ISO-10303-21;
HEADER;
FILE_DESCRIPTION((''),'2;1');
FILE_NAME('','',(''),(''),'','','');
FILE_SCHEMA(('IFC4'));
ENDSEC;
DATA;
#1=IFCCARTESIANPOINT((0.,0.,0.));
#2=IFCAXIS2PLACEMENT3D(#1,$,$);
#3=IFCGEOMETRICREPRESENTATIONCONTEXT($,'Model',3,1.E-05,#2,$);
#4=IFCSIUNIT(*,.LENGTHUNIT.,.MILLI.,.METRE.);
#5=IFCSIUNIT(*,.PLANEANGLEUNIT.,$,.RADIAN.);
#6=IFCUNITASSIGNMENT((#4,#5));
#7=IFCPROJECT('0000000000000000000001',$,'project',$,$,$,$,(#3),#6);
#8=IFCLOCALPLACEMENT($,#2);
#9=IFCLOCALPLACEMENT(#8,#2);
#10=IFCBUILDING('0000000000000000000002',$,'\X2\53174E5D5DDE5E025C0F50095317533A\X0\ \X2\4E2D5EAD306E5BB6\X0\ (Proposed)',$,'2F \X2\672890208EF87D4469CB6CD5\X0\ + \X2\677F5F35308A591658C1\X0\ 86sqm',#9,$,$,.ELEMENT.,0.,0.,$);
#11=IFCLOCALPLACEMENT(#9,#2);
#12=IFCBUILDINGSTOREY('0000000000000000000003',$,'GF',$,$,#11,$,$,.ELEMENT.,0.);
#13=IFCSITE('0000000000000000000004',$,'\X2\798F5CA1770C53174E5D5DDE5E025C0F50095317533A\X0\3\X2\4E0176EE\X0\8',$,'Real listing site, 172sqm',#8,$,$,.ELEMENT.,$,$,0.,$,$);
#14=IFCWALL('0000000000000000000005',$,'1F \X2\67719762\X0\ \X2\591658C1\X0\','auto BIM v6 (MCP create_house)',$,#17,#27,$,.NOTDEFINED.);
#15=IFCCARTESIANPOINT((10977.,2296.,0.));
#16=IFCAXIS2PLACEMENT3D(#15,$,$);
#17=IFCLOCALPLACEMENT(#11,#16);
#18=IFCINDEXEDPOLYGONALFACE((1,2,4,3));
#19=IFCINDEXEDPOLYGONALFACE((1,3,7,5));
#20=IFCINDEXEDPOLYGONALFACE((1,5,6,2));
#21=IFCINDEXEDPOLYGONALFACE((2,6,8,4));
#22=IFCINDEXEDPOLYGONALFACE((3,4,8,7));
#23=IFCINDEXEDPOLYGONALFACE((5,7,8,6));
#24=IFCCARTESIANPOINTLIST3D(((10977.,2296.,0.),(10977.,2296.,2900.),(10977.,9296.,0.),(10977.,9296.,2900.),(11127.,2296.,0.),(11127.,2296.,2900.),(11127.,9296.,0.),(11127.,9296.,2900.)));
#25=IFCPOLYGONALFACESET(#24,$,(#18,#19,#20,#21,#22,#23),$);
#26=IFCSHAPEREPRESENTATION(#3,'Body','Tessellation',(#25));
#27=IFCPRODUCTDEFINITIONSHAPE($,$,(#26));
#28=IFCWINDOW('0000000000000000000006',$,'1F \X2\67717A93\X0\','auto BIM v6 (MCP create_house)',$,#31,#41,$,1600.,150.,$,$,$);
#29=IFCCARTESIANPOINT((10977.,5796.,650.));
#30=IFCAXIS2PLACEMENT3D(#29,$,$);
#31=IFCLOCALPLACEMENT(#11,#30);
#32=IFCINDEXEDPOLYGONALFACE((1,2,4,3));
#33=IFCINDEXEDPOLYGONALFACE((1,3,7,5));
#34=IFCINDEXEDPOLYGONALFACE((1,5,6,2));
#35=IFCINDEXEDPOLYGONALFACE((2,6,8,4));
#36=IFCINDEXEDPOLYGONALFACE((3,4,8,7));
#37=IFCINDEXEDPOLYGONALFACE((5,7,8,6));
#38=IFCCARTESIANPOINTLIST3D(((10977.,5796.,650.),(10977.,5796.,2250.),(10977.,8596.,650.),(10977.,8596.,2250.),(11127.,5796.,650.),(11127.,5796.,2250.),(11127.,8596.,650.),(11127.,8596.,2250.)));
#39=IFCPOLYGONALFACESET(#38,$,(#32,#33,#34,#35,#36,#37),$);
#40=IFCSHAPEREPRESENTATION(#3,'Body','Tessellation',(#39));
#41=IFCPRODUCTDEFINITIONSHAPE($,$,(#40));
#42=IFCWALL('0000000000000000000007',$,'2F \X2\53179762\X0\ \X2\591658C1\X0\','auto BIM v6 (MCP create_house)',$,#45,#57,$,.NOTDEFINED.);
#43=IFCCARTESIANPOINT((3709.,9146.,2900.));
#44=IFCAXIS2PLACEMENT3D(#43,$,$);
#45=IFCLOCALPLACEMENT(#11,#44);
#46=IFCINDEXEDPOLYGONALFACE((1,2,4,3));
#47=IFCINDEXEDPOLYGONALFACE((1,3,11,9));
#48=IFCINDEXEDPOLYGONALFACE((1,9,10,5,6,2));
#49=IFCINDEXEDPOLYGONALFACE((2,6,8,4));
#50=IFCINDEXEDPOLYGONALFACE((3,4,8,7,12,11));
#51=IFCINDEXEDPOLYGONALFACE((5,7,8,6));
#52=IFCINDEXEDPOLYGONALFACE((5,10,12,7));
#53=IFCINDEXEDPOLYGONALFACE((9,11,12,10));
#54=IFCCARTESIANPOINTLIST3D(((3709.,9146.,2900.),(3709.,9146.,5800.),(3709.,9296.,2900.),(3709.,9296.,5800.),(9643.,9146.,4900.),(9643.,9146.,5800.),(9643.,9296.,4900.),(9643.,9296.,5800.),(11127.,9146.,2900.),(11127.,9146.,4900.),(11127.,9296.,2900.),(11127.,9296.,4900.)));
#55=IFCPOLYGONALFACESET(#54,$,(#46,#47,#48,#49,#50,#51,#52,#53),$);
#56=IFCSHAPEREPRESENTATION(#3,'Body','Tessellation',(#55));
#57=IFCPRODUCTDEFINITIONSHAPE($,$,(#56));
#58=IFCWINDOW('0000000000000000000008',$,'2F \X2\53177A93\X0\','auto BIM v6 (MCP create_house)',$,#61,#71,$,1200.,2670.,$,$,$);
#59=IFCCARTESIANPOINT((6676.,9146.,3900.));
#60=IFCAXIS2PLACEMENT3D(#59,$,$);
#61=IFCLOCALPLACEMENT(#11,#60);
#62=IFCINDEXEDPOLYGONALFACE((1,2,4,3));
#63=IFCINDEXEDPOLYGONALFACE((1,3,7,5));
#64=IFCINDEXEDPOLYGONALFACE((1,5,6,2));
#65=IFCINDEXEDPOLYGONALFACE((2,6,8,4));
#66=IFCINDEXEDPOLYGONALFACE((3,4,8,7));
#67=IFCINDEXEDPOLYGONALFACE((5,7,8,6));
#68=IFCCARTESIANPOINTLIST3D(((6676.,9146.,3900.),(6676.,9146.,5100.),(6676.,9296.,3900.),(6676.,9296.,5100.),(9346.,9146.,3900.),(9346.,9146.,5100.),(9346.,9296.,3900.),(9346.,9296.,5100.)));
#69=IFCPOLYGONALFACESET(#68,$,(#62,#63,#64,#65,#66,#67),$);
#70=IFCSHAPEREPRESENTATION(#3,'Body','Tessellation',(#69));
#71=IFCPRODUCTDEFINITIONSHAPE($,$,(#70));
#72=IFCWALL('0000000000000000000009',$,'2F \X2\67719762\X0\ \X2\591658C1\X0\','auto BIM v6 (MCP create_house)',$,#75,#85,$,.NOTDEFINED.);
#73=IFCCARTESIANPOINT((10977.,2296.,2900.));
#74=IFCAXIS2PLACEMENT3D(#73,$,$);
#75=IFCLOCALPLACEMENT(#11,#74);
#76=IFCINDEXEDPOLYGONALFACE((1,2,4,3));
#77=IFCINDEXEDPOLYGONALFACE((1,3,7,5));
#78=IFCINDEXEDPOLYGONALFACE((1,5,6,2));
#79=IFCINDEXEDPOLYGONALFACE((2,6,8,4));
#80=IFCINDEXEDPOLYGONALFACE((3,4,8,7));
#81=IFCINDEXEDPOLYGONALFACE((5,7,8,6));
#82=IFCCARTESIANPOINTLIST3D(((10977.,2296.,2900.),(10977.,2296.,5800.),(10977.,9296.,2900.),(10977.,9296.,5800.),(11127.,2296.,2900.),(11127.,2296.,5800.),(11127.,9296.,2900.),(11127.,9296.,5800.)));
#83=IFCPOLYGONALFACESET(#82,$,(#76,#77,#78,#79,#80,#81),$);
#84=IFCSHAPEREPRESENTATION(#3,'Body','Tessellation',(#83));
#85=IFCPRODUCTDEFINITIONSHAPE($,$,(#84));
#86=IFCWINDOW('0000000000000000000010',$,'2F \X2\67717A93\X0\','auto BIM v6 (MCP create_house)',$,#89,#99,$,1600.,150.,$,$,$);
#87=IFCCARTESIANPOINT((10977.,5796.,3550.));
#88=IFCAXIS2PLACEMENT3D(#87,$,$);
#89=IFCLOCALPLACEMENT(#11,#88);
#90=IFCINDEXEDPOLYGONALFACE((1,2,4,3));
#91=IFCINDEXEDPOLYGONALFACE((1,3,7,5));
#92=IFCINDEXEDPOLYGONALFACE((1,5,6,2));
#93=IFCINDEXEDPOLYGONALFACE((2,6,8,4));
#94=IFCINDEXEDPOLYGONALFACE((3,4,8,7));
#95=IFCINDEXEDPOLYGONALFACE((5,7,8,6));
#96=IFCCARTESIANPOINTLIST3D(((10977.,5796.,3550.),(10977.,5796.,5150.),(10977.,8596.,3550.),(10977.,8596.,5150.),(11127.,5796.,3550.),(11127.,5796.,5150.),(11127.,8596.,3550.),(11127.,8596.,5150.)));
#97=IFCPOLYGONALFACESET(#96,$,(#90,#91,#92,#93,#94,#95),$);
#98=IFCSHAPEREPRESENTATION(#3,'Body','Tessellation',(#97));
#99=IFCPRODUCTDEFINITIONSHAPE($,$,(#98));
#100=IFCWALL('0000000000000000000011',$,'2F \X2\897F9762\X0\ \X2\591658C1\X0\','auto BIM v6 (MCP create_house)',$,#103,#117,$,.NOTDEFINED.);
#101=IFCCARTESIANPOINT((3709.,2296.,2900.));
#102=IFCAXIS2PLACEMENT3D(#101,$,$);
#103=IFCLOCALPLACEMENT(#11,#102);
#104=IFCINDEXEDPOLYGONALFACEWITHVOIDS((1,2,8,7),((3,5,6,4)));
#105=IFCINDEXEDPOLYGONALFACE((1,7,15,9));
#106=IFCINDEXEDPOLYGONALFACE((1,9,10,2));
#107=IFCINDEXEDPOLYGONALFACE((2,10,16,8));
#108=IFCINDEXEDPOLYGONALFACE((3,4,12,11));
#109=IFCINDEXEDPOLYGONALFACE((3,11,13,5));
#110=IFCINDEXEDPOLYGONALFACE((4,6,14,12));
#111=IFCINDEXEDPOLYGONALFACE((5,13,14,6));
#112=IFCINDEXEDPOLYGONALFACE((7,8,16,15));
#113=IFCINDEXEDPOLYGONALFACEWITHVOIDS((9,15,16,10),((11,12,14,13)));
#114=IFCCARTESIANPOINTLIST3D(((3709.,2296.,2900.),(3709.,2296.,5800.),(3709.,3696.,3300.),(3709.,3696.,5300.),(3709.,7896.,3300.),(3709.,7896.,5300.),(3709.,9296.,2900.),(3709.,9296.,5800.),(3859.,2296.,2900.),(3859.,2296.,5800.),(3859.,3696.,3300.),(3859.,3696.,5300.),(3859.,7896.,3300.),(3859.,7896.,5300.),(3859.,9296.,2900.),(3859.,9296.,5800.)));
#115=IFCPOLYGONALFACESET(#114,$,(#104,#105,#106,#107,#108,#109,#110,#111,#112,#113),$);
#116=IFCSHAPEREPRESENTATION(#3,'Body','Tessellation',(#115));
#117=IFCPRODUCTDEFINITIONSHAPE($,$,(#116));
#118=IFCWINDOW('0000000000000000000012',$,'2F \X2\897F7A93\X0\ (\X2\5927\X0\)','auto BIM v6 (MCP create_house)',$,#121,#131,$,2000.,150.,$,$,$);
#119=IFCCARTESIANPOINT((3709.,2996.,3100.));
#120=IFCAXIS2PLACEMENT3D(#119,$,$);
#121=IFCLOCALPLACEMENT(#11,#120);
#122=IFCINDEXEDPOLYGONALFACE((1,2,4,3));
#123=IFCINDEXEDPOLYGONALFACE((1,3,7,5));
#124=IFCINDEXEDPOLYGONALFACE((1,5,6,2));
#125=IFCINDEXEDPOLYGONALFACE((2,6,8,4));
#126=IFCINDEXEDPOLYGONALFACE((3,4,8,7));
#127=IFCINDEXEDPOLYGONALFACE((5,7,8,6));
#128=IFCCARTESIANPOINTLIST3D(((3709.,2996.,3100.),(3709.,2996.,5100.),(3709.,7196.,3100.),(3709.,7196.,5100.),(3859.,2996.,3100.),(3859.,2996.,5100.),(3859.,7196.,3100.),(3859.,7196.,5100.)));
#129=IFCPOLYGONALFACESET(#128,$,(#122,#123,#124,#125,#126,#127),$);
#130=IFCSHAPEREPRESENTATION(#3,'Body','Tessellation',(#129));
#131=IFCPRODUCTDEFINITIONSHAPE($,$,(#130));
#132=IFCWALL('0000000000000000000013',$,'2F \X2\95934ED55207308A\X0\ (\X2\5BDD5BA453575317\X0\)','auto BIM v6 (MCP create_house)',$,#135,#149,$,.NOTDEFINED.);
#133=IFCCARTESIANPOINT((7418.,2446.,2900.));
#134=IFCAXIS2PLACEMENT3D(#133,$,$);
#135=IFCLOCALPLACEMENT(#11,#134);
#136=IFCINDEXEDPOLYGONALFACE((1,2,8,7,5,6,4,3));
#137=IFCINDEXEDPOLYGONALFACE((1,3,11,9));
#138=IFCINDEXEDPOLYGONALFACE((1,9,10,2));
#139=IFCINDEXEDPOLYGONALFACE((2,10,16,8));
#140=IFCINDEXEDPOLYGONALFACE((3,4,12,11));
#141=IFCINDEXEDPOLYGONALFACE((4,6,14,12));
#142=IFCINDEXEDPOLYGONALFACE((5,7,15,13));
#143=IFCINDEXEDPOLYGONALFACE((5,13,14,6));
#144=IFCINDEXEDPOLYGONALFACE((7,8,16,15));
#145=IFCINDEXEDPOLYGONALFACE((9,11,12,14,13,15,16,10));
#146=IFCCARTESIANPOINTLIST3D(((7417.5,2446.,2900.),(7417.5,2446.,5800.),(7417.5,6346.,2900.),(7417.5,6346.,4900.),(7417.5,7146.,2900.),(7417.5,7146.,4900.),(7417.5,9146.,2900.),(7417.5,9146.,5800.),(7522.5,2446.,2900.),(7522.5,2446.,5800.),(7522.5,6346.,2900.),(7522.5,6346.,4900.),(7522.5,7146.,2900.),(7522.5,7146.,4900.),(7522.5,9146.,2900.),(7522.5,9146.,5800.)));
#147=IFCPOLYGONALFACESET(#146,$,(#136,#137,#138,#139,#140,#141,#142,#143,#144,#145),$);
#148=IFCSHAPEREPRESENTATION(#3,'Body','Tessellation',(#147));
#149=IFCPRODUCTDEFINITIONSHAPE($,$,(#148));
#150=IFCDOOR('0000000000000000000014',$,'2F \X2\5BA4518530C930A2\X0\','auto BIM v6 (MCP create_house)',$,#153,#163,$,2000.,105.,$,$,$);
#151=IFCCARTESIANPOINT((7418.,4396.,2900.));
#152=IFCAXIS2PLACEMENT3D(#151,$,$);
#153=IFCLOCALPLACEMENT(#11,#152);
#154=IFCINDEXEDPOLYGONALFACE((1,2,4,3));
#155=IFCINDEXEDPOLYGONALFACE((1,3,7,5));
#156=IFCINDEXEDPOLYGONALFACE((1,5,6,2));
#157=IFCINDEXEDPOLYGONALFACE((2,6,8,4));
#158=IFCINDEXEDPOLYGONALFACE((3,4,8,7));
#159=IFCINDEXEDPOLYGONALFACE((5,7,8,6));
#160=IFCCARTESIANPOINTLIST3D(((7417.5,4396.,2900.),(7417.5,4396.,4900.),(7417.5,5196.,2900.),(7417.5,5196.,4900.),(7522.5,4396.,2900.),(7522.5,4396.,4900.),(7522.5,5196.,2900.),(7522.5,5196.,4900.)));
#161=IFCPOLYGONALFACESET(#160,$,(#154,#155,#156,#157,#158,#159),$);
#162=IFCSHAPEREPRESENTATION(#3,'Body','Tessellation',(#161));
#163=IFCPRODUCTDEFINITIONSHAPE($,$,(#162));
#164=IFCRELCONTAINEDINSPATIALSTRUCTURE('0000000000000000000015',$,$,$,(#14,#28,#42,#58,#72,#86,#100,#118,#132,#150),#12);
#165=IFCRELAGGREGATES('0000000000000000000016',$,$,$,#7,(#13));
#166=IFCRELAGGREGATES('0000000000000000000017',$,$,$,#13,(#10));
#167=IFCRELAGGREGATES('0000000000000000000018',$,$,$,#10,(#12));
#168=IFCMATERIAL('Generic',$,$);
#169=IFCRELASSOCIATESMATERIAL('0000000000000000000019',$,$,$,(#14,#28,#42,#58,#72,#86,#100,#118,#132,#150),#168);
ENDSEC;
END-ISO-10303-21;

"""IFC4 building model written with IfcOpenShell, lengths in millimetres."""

from ifc_helpers import new_model, si_unit, frame, frame_2d, origin, place, context, project, spatial, rectangle, extrude, material, element, fill, save


model = new_model("IFC4")

# Units and contexts
model_context = context("Model", 3, precision=1e-05, world=origin())
ifc_project = project(units=[si_unit("LENGTHUNIT", "METRE", prefix="MILLI"), si_unit("PLANEANGLEUNIT", "RADIAN")], contexts=[model_context])

# Site, building, storey
site_placement = place(None, origin())
site = spatial("IfcSite", under=ifc_project, at=site_placement, Name="福岡県北九州市小倉北区3丁目8", ObjectType="Real listing site, 172sqm", CompositionType="ELEMENT", RefElevation=0.0)
building_placement = place(site_placement, origin())
building = spatial("IfcBuilding", under=site, at=building_placement, Name="北九州市小倉北区 中庭の家 (Proposed)", ObjectType="2F 木造軸組構法 + 板張り外壁 86sqm", CompositionType="ELEMENT", ElevationOfRefHeight=0.0, ElevationOfTerrain=0.0)
storey_placement = place(building_placement, origin())
storey = spatial("IfcBuildingStorey", under=building, at=storey_placement, Name="GF", CompositionType="ELEMENT", Elevation=0.0)

# Shared definitions
ifc_material = material(Name="Generic")

# Wall, opening, window
wall_1_placement = place(storey_placement, frame((10977.0, 2296.0, 0.0)))
wall_1 = element("IfcWall", 1, at=wall_1_placement, inside=storey, material=ifc_material, Name="1F 東面 外壁", Description="auto BIM v6 (MCP create_house)", PredefinedType="NOTDEFINED", context=model_context, shape_type="SweptSolid", body=[
    extrude(rectangle(XDim=150.0, YDim=7000.0, at=frame_2d((75.0, 3500.0))), frame((10977.0, 2296.0, 0.0)), (0.0, 0.0, 1.0), 2900.0),
])
opening_1_placement = place(storey_placement, frame((10977.0, 5796.0, 650.0)))
opening_1 = element("IfcOpeningElement", 2, at=opening_1_placement, cuts=wall_1, PredefinedType="NOTDEFINED", context=model_context, shape_type="SweptSolid", body=[
    extrude(rectangle(XDim=150.0, YDim=2800.0, at=frame_2d((75.0, 1400.0))), frame((10977.0, 5796.0, 650.0)), (0.0, 0.0, 1.0), 1600.0),
])
window_1_placement = place(storey_placement, frame((10977.0, 5796.0, 650.0)))
window_1 = element("IfcWindow", 3, at=window_1_placement, inside=storey, material=ifc_material, Name="1F 東窓", Description="auto BIM v6 (MCP create_house)", OverallHeight=1600.0, OverallWidth=150.0, context=model_context, shape_type="SweptSolid", body=[
    extrude(rectangle(XDim=150.0, YDim=2800.0, at=frame_2d((75.0, 1400.0))), frame((10977.0, 5796.0, 650.0)), (0.0, 0.0, 1.0), 1600.0),
])
fill(opening_1, window_1)

# Walls, openings, windows
wall_2_placement = place(storey_placement, frame((3709.0, 9146.0, 2900.0)))
wall_2 = element("IfcWall", 4, at=wall_2_placement, inside=storey, material=ifc_material, Name="2F 北面 外壁", Description="auto BIM v6 (MCP create_house)", PredefinedType="NOTDEFINED", context=model_context, shape_type="SweptSolid", body=[
    extrude(rectangle(XDim=7418.0, YDim=150.0, at=frame_2d((3709.0, 75.0))), frame((3709.0, 9146.0, 2900.0)), (0.0, 0.0, 1.0), 2900.0),
])
opening_2_placement = place(storey_placement, frame((6676.0, 9146.0, 3900.0)))
opening_2 = element("IfcOpeningElement", 5, at=opening_2_placement, cuts=wall_2, PredefinedType="NOTDEFINED", context=model_context, shape_type="SweptSolid", body=[
    extrude(rectangle(XDim=2670.0, YDim=150.0, at=frame_2d((1335.0, 75.0))), frame((6676.0, 9146.0, 3900.0)), (0.0, 0.0, 1.0), 1200.0),
])
window_2_placement = place(storey_placement, frame((6676.0, 9146.0, 3900.0)))
window_2 = element("IfcWindow", 6, at=window_2_placement, inside=storey, material=ifc_material, Name="2F 北窓", Description="auto BIM v6 (MCP create_house)", OverallHeight=1200.0, OverallWidth=2670.0, context=model_context, shape_type="SweptSolid", body=[
    extrude(rectangle(XDim=2670.0, YDim=150.0, at=frame_2d((1335.0, 75.0))), frame((6676.0, 9146.0, 3900.0)), (0.0, 0.0, 1.0), 1200.0),
])
fill(opening_2, window_2)
wall_3_placement = place(storey_placement, frame((10977.0, 2296.0, 2900.0)))
wall_3 = element("IfcWall", 7, at=wall_3_placement, inside=storey, material=ifc_material, Name="2F 東面 外壁", Description="auto BIM v6 (MCP create_house)", PredefinedType="NOTDEFINED", context=model_context, shape_type="SweptSolid", body=[
    extrude(rectangle(XDim=150.0, YDim=7000.0, at=frame_2d((75.0, 3500.0))), frame((10977.0, 2296.0, 2900.0)), (0.0, 0.0, 1.0), 2900.0),
])
opening_3_placement = place(storey_placement, frame((10977.0, 5796.0, 3550.0)))
opening_3 = element("IfcOpeningElement", 8, at=opening_3_placement, cuts=wall_3, PredefinedType="NOTDEFINED", context=model_context, shape_type="SweptSolid", body=[
    extrude(rectangle(XDim=150.0, YDim=2800.0, at=frame_2d((75.0, 1400.0))), frame((10977.0, 5796.0, 3550.0)), (0.0, 0.0, 1.0), 1600.0),
])
window_3_placement = place(storey_placement, frame((10977.0, 5796.0, 3550.0)))
window_3 = element("IfcWindow", 9, at=window_3_placement, inside=storey, material=ifc_material, Name="2F 東窓", Description="auto BIM v6 (MCP create_house)", OverallHeight=1600.0, OverallWidth=150.0, context=model_context, shape_type="SweptSolid", body=[
    extrude(rectangle(XDim=150.0, YDim=2800.0, at=frame_2d((75.0, 1400.0))), frame((10977.0, 5796.0, 3550.0)), (0.0, 0.0, 1.0), 1600.0),
])
fill(opening_3, window_3)
wall_4_placement = place(storey_placement, frame((3709.0, 2296.0, 2900.0)))
wall_4 = element("IfcWall", 10, at=wall_4_placement, inside=storey, material=ifc_material, Name="2F 西面 外壁", Description="auto BIM v6 (MCP create_house)", PredefinedType="NOTDEFINED", context=model_context, shape_type="SweptSolid", body=[
    extrude(rectangle(XDim=150.0, YDim=7000.0, at=frame_2d((75.0, 3500.0))), frame((3709.0, 2296.0, 2900.0)), (0.0, 0.0, 1.0), 2900.0),
])
opening_4_placement = place(storey_placement, frame((3709.0, 2996.0, 3100.0)))
opening_4 = element("IfcOpeningElement", 11, at=opening_4_placement, cuts=wall_4, PredefinedType="NOTDEFINED", context=model_context, shape_type="SweptSolid", body=[
    extrude(rectangle(XDim=150.0, YDim=4200.0, at=frame_2d((75.0, 2100.0))), frame((3709.0, 2996.0, 3100.0)), (0.0, 0.0, 1.0), 2000.0),
])
window_4_placement = place(storey_placement, frame((3709.0, 2996.0, 3100.0)))
window_4 = element("IfcWindow", 12, at=window_4_placement, inside=storey, material=ifc_material, Name="2F 西窓 (大)", Description="auto BIM v6 (MCP create_house)", OverallHeight=2000.0, OverallWidth=150.0, context=model_context, shape_type="SweptSolid", body=[
    extrude(rectangle(XDim=150.0, YDim=4200.0, at=frame_2d((75.0, 2100.0))), frame((3709.0, 2996.0, 3100.0)), (0.0, 0.0, 1.0), 2000.0),
])
fill(opening_4, window_4)

# Wall, opening, door
wall_5_placement = place(storey_placement, frame((7418.0, 2446.0, 2900.0)))
wall_5 = element("IfcWall", 13, at=wall_5_placement, inside=storey, material=ifc_material, Name="2F 間仕切り (寝室南北)", Description="auto BIM v6 (MCP create_house)", PredefinedType="NOTDEFINED", context=model_context, shape_type="SweptSolid", body=[
    extrude(rectangle(XDim=105.0, YDim=6700.0, at=frame_2d((52.0, 3350.0))), frame((7418.0, 2446.0, 2900.0)), (0.0, 0.0, 1.0), 2900.0),
])
opening_5_placement = place(storey_placement, frame((7418.0, 4396.0, 2900.0)))
opening_5 = element("IfcOpeningElement", 14, at=opening_5_placement, cuts=wall_5, PredefinedType="NOTDEFINED", context=model_context, shape_type="SweptSolid", body=[
    extrude(rectangle(XDim=105.0, YDim=800.0, at=frame_2d((52.0, 400.0))), frame((7418.0, 4396.0, 2900.0)), (0.0, 0.0, 1.0), 2000.0),
])
door_placement = place(storey_placement, frame((7418.0, 4396.0, 2900.0)))
door = element("IfcDoor", 15, at=door_placement, inside=storey, material=ifc_material, Name="2F 室内ドア", Description="auto BIM v6 (MCP create_house)", OverallHeight=2000.0, OverallWidth=105.0, context=model_context, shape_type="SweptSolid", body=[
    extrude(rectangle(XDim=105.0, YDim=800.0, at=frame_2d((52.0, 400.0))), frame((7418.0, 4396.0, 2900.0)), (0.0, 0.0, 1.0), 2000.0),
])
fill(opening_5, door)

save(model, "model.ifc")
